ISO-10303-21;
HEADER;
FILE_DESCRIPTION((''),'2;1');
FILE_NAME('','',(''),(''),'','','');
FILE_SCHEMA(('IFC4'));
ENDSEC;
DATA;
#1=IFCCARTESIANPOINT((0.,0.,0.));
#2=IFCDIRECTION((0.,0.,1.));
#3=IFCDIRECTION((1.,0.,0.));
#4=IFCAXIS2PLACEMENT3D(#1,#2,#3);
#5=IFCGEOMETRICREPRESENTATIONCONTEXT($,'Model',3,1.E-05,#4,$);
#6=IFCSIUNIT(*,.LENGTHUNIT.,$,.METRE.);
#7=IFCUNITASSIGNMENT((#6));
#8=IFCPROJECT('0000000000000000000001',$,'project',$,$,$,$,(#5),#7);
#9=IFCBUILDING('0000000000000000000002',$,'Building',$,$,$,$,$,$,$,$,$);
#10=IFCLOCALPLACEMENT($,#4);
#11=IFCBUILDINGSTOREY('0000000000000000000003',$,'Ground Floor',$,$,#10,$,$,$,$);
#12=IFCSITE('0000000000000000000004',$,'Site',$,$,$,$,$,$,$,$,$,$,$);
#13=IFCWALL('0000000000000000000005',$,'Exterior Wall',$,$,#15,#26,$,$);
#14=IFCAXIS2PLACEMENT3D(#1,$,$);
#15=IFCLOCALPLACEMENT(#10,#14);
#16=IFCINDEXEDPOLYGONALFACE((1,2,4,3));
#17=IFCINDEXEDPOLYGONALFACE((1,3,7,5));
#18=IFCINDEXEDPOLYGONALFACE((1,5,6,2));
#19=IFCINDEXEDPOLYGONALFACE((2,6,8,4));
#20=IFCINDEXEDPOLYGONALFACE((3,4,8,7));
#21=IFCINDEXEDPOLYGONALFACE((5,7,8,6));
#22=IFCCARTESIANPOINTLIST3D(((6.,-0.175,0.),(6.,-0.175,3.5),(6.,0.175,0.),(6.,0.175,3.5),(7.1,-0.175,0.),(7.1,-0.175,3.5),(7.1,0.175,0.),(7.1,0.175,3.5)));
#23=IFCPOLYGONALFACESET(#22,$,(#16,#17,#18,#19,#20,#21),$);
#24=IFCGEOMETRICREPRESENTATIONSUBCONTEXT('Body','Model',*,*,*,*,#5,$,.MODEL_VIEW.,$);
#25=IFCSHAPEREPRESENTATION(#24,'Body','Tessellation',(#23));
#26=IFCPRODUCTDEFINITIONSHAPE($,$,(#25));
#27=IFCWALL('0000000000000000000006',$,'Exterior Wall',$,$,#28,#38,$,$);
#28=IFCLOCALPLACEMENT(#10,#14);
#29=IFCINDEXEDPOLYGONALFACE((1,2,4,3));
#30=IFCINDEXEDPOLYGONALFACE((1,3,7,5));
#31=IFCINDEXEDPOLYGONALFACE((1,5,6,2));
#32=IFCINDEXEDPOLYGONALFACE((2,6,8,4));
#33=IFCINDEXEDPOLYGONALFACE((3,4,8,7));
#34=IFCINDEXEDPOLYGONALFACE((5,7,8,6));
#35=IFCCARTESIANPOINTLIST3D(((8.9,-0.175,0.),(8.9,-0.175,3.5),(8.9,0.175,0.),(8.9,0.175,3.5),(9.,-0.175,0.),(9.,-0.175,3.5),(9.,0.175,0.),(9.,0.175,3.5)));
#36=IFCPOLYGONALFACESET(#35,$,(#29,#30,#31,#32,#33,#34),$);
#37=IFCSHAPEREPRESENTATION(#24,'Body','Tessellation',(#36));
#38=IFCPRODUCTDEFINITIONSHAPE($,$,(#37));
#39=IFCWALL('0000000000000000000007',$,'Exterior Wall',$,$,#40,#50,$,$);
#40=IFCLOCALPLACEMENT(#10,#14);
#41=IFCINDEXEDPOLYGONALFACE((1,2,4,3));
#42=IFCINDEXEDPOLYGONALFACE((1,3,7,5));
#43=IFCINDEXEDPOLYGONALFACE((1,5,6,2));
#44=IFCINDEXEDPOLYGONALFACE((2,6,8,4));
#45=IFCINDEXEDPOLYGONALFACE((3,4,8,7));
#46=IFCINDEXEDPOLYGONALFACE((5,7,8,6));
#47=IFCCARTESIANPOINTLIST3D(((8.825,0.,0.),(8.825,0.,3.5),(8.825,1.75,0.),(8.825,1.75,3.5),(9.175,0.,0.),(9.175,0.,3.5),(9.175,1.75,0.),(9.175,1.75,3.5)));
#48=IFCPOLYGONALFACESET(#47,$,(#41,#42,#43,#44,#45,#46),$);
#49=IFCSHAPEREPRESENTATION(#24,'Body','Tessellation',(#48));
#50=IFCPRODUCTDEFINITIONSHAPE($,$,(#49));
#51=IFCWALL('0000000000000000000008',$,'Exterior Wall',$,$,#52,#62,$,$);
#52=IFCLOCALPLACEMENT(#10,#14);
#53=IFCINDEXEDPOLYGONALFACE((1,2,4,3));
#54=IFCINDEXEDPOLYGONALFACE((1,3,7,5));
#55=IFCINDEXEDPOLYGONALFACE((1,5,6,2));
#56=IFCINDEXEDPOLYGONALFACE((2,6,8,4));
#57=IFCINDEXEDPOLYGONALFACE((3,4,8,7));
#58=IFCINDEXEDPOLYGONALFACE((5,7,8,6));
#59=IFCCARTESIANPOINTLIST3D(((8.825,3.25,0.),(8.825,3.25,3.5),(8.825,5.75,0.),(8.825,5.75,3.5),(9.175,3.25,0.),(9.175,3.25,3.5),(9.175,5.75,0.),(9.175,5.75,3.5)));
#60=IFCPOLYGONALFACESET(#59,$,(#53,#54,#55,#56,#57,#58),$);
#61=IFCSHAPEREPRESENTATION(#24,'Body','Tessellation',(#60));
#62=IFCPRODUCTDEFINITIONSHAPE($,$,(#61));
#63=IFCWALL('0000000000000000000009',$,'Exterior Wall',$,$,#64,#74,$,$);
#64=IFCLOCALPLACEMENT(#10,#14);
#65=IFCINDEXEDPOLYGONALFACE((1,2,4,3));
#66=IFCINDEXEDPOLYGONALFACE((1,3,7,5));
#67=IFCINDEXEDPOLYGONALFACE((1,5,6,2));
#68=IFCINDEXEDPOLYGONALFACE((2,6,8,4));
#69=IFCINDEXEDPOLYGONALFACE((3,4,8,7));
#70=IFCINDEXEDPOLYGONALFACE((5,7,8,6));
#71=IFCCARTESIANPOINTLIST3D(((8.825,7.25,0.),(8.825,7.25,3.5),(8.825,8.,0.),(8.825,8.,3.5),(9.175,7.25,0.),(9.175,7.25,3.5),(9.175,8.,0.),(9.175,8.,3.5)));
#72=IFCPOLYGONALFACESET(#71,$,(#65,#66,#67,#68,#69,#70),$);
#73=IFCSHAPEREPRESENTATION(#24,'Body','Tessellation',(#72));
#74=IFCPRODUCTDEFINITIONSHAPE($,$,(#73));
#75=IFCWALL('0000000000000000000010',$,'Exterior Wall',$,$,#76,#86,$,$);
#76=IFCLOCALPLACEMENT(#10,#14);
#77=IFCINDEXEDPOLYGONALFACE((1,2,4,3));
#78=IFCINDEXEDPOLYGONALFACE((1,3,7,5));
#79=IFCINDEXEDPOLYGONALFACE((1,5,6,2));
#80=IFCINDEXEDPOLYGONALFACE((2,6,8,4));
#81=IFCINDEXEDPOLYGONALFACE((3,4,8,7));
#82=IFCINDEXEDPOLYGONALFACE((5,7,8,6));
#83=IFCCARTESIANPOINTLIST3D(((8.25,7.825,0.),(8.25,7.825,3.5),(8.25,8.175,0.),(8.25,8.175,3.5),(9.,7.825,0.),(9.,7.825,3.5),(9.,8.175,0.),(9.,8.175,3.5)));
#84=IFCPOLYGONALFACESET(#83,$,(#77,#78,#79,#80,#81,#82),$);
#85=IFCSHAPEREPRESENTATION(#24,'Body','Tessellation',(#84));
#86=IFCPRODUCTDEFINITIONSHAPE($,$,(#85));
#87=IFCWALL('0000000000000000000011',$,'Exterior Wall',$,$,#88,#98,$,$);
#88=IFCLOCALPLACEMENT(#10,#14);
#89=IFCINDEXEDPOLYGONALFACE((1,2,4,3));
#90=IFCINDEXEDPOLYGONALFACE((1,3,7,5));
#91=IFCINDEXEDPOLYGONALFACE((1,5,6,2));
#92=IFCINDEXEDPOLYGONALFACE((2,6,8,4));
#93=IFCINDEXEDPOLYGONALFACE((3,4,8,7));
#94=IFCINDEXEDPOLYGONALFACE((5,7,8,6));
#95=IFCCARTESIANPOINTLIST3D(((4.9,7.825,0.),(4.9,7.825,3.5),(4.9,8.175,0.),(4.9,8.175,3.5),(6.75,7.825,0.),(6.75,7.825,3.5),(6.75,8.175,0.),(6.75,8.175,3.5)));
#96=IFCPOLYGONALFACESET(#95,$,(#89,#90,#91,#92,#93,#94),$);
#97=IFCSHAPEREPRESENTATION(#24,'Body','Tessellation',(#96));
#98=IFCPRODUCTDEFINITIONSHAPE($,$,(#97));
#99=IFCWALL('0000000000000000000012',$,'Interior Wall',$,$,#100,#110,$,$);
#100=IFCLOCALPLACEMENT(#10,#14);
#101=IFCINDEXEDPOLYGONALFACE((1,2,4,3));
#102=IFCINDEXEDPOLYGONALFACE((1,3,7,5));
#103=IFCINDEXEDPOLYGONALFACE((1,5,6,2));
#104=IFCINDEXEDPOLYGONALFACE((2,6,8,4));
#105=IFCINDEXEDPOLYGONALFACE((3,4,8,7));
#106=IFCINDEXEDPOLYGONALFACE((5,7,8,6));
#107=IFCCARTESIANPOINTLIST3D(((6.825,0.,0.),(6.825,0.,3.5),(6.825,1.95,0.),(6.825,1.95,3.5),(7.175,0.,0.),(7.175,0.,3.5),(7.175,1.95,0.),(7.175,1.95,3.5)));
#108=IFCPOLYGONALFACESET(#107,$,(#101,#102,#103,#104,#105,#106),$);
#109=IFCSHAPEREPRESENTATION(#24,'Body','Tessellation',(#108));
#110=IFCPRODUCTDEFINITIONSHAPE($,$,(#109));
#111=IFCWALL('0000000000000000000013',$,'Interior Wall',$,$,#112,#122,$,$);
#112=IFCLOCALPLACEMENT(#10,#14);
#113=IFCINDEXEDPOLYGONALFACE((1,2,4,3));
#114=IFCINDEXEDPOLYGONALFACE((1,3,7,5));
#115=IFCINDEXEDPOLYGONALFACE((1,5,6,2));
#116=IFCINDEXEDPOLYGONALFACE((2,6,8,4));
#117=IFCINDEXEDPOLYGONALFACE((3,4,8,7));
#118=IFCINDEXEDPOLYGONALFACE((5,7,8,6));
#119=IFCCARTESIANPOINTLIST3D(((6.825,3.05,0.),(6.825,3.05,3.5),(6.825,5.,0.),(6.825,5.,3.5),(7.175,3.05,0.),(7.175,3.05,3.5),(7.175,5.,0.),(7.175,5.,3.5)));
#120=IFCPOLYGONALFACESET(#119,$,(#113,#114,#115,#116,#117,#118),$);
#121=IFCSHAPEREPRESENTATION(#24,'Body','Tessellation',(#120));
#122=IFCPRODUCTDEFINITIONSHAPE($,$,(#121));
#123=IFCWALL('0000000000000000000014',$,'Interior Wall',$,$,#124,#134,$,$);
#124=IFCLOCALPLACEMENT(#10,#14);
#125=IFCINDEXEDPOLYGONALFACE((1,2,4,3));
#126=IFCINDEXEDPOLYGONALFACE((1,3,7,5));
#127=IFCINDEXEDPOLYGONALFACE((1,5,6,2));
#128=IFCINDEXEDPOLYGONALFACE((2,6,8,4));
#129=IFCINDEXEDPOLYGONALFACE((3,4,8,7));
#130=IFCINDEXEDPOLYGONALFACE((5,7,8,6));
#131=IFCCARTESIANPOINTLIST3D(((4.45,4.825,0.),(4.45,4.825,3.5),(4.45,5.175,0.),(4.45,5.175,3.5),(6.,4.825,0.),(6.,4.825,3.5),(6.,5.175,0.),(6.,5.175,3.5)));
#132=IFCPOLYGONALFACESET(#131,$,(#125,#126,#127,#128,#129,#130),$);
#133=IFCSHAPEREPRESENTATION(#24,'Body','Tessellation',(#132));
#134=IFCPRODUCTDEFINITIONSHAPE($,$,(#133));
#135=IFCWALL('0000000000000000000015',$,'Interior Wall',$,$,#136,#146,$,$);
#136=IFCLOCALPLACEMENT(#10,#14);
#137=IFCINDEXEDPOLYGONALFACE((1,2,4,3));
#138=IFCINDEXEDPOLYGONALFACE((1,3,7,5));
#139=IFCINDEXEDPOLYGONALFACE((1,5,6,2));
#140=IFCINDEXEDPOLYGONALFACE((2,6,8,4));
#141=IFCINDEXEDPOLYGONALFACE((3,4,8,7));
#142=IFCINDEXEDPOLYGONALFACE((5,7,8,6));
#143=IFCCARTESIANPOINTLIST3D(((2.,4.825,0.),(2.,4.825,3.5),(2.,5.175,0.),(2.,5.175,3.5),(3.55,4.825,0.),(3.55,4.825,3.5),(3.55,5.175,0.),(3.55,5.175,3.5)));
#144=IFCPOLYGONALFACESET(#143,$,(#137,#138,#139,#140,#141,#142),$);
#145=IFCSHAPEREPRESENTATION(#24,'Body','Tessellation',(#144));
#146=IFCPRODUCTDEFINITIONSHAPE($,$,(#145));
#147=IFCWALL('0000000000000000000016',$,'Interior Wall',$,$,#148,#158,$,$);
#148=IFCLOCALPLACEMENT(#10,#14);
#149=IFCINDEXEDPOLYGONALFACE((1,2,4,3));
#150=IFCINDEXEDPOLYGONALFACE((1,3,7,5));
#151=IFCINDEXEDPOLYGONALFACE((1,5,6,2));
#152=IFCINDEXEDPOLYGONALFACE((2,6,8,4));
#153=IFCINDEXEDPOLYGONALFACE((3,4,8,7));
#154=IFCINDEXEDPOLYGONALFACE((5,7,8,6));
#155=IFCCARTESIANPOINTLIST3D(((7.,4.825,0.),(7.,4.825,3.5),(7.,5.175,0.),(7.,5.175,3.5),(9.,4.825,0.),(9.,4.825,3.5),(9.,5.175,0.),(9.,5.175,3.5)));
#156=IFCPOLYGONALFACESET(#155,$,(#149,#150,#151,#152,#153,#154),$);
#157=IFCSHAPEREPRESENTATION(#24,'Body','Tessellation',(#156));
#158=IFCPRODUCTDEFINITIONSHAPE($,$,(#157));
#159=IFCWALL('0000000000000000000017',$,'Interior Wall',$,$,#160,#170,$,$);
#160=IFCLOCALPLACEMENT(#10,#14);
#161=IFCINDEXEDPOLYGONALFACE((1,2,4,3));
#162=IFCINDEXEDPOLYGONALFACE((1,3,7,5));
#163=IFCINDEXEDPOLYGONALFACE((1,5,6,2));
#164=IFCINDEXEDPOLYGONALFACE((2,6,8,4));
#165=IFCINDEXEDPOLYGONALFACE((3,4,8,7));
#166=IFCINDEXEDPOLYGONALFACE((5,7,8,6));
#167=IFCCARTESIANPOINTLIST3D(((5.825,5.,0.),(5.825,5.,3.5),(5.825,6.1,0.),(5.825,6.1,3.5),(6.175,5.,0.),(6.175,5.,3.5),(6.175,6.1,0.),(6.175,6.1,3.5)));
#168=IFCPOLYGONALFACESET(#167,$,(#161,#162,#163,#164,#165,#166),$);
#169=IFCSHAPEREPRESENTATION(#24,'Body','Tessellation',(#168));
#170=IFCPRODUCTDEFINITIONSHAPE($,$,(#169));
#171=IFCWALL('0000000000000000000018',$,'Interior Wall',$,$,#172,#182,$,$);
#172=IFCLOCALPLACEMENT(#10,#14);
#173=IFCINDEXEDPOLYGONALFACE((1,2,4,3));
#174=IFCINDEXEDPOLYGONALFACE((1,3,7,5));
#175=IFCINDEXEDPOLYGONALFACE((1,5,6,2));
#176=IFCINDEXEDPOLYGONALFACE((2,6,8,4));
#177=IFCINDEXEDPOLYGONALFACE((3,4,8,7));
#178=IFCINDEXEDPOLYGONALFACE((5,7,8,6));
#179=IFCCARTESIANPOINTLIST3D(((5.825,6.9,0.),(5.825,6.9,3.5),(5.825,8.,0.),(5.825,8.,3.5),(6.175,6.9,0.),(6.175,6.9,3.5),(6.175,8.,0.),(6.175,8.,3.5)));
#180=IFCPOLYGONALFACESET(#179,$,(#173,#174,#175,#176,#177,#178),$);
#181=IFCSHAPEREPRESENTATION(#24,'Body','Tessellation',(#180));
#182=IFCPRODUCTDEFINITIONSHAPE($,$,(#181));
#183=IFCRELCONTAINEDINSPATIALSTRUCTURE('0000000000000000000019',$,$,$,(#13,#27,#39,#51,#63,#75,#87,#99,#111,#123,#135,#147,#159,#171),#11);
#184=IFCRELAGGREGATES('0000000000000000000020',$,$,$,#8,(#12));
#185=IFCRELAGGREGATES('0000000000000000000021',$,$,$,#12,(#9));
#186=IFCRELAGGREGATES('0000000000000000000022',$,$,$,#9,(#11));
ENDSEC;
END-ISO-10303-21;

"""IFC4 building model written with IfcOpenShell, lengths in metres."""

from ifc_helpers import new_model, si_unit, frame, origin_with_axes, place, context, subcontext, project, spatial, indexed_curve, outline, extrude, element, save


model = new_model("IFC4")

# Units and contexts
model_context = context("Model", 3, precision=1e-05, world=origin_with_axes())
body_context = subcontext(model_context, "Body", "Model", "MODEL_VIEW")
ifc_project = project(units=[si_unit("LENGTHUNIT", "METRE")], contexts=[model_context])

# Site, building, storey
site = spatial("IfcSite", under=ifc_project, Name="Site")
building = spatial("IfcBuilding", under=site, Name="Building")
storey_placement = place(None, origin_with_axes())
storey = spatial("IfcBuildingStorey", under=building, at=storey_placement, Name="Ground Floor")

# Walls
wall_1_placement = place(storey_placement, frame((6.0, 0.0, 0.0), z_axis=(0.0, 0.0, 1.0), x_axis=(1.0, 0.0, 0.0)))
element("IfcWall", 1, at=wall_1_placement, inside=storey, Name="Exterior Wall", context=body_context, shape_type="SweptSolid", body=[
    extrude(outline(indexed_curve([(0.0, 0.0), (0.0, 0.35), (1.1, 0.35), (1.1, 0.0), (0.0, 0.0)], self_intersect=False)), frame((0.0, -0.175, 0.0), z_axis=(0.0, 0.0, 1.0), x_axis=(1.0, 0.0, 0.0)), (0.0, 0.0, 1.0), 3.5),
])
wall_2_placement = place(storey_placement, frame((8.9, 0.0, 0.0), z_axis=(0.0, 0.0, 1.0), x_axis=(1.0, 0.0, 0.0)))
element("IfcWall", 2, at=wall_2_placement, inside=storey, Name="Exterior Wall", context=body_context, shape_type="SweptSolid", body=[
    extrude(outline(indexed_curve([(0.0, 0.0), (0.0, 0.35), (0.1, 0.35), (0.1, 0.0), (0.0, 0.0)], self_intersect=False)), frame((0.0, -0.175, 0.0), z_axis=(0.0, 0.0, 1.0), x_axis=(1.0, 0.0, 0.0)), (0.0, 0.0, 1.0), 3.5),
])
wall_3_placement = place(storey_placement, frame((9.0, 0.0, 0.0), z_axis=(0.0, 0.0, 1.0), x_axis=(0.0, 1.0, 0.0)))
element("IfcWall", 3, at=wall_3_placement, inside=storey, Name="Exterior Wall", context=body_context, shape_type="SweptSolid", body=[
    extrude(outline(indexed_curve([(0.0, 0.0), (0.0, 0.35), (1.75, 0.35), (1.75, 0.0), (0.0, 0.0)], self_intersect=False)), frame((0.0, -0.175, 0.0), z_axis=(0.0, 0.0, 1.0), x_axis=(1.0, 0.0, 0.0)), (0.0, 0.0, 1.0), 3.5),
])
wall_4_placement = place(storey_placement, frame((9.0, 3.25, 0.0), z_axis=(0.0, 0.0, 1.0), x_axis=(0.0, 1.0, 0.0)))
element("IfcWall", 4, at=wall_4_placement, inside=storey, Name="Exterior Wall", context=body_context, shape_type="SweptSolid", body=[
    extrude(outline(indexed_curve([(0.0, 0.0), (0.0, 0.35), (2.5, 0.35), (2.5, 0.0), (0.0, 0.0)], self_intersect=False)), frame((0.0, -0.175, 0.0), z_axis=(0.0, 0.0, 1.0), x_axis=(1.0, 0.0, 0.0)), (0.0, 0.0, 1.0), 3.5),
])
for number, where, z_axis, x_axis, name in (
    (5, (9.0, 7.25, 0.0), (0.0, 0.0, 1.0), (0.0, 1.0, 0.0), "Exterior Wall"),
    (6, (9.0, 8.0, 0.0), (0.0, 0.0, 1.0), (-1.0, 0.0, 0.0), "Exterior Wall"),
):
    element("IfcWall", number, at=place(storey_placement, frame(where, z_axis=z_axis, x_axis=x_axis)), inside=storey, Name=name, context=body_context, shape_type="SweptSolid", body=[
        extrude(outline(indexed_curve([(0.0, 0.0), (0.0, 0.35), (0.75, 0.35), (0.75, 0.0), (0.0, 0.0)], self_intersect=False)), frame((0.0, -0.175, 0.0), z_axis=(0.0, 0.0, 1.0), x_axis=(1.0, 0.0, 0.0)), (0.0, 0.0, 1.0), 3.5),
    ])
wall_5_placement = place(storey_placement, frame((6.75, 8.0, 0.0), z_axis=(0.0, 0.0, 1.0), x_axis=(-1.0, 0.0, 0.0)))
element("IfcWall", 7, at=wall_5_placement, inside=storey, Name="Exterior Wall", context=body_context, shape_type="SweptSolid", body=[
    extrude(outline(indexed_curve([(0.0, 0.0), (0.0, 0.35), (1.85, 0.35), (1.85, 0.0), (0.0, 0.0)], self_intersect=False)), frame((0.0, -0.175, 0.0), z_axis=(0.0, 0.0, 1.0), x_axis=(1.0, 0.0, 0.0)), (0.0, 0.0, 1.0), 3.5),
])
wall_6_placement = place(storey_placement, frame((7.0, 0.0, 0.0), z_axis=(0.0, 0.0, 1.0), x_axis=(0.0, 1.0, 0.0)))
element("IfcWall", 8, at=wall_6_placement, inside=storey, Name="Interior Wall", context=body_context, shape_type="SweptSolid", body=[
    extrude(outline(indexed_curve([(0.0, 0.0), (0.0, 0.35), (1.95, 0.35), (1.95, 0.0), (0.0, 0.0)], self_intersect=False)), frame((0.0, -0.175, 0.0), z_axis=(0.0, 0.0, 1.0), x_axis=(1.0, 0.0, 0.0)), (0.0, 0.0, 1.0), 3.5),
])
wall_7_placement = place(storey_placement, frame((7.0, 3.05, 0.0), z_axis=(0.0, 0.0, 1.0), x_axis=(0.0, 1.0, 0.0)))
element("IfcWall", 9, at=wall_7_placement, inside=storey, Name="Interior Wall", context=body_context, shape_type="SweptSolid", body=[
    extrude(outline(indexed_curve([(0.0, 0.0), (0.0, 0.35), (1.95, 0.35), (1.95, 0.0), (0.0, 0.0)], self_intersect=False)), frame((0.0, -0.175, 0.0), z_axis=(0.0, 0.0, 1.0), x_axis=(1.0, 0.0, 0.0)), (0.0, 0.0, 1.0), 3.5),
])
for number, where, z_axis, x_axis, name in (
    (10, (6.0, 5.0, 0.0), (0.0, 0.0, 1.0), (-1.0, 0.0, 0.0), "Interior Wall"),
    (11, (3.55, 5.0, 0.0), (0.0, 0.0, 1.0), (-1.0, 0.0, 0.0), "Interior Wall"),
):
    element("IfcWall", number, at=place(storey_placement, frame(where, z_axis=z_axis, x_axis=x_axis)), inside=storey, Name=name, context=body_context, shape_type="SweptSolid", body=[
        extrude(outline(indexed_curve([(0.0, 0.0), (0.0, 0.35), (1.55, 0.35), (1.55, 0.0), (0.0, 0.0)], self_intersect=False)), frame((0.0, -0.175, 0.0), z_axis=(0.0, 0.0, 1.0), x_axis=(1.0, 0.0, 0.0)), (0.0, 0.0, 1.0), 3.5),
    ])
wall_8_placement = place(storey_placement, frame((9.0, 5.0, 0.0), z_axis=(0.0, 0.0, 1.0), x_axis=(-1.0, 0.0, 0.0)))
element("IfcWall", 12, at=wall_8_placement, inside=storey, Name="Interior Wall", context=body_context, shape_type="SweptSolid", body=[
    extrude(outline(indexed_curve([(0.0, 0.0), (0.0, 0.35), (2.0, 0.35), (2.0, 0.0), (0.0, 0.0)], self_intersect=False)), frame((0.0, -0.175, 0.0), z_axis=(0.0, 0.0, 1.0), x_axis=(1.0, 0.0, 0.0)), (0.0, 0.0, 1.0), 3.5),
])
for number, where, z_axis, x_axis, name in (
    (13, (6.0, 5.0, 0.0), (0.0, 0.0, 1.0), (0.0, 1.0, 0.0), "Interior Wall"),
    (14, (6.0, 6.9, 0.0), (0.0, 0.0, 1.0), (0.0, 1.0, 0.0), "Interior Wall"),
):
    element("IfcWall", number, at=place(storey_placement, frame(where, z_axis=z_axis, x_axis=x_axis)), inside=storey, Name=name, context=body_context, shape_type="SweptSolid", body=[
        extrude(outline(indexed_curve([(0.0, 0.0), (0.0, 0.35), (1.1, 0.35), (1.1, 0.0), (0.0, 0.0)], self_intersect=False)), frame((0.0, -0.175, 0.0), z_axis=(0.0, 0.0, 1.0), x_axis=(1.0, 0.0, 0.0)), (0.0, 0.0, 1.0), 3.5),
    ])

save(model, "model.ifc")
